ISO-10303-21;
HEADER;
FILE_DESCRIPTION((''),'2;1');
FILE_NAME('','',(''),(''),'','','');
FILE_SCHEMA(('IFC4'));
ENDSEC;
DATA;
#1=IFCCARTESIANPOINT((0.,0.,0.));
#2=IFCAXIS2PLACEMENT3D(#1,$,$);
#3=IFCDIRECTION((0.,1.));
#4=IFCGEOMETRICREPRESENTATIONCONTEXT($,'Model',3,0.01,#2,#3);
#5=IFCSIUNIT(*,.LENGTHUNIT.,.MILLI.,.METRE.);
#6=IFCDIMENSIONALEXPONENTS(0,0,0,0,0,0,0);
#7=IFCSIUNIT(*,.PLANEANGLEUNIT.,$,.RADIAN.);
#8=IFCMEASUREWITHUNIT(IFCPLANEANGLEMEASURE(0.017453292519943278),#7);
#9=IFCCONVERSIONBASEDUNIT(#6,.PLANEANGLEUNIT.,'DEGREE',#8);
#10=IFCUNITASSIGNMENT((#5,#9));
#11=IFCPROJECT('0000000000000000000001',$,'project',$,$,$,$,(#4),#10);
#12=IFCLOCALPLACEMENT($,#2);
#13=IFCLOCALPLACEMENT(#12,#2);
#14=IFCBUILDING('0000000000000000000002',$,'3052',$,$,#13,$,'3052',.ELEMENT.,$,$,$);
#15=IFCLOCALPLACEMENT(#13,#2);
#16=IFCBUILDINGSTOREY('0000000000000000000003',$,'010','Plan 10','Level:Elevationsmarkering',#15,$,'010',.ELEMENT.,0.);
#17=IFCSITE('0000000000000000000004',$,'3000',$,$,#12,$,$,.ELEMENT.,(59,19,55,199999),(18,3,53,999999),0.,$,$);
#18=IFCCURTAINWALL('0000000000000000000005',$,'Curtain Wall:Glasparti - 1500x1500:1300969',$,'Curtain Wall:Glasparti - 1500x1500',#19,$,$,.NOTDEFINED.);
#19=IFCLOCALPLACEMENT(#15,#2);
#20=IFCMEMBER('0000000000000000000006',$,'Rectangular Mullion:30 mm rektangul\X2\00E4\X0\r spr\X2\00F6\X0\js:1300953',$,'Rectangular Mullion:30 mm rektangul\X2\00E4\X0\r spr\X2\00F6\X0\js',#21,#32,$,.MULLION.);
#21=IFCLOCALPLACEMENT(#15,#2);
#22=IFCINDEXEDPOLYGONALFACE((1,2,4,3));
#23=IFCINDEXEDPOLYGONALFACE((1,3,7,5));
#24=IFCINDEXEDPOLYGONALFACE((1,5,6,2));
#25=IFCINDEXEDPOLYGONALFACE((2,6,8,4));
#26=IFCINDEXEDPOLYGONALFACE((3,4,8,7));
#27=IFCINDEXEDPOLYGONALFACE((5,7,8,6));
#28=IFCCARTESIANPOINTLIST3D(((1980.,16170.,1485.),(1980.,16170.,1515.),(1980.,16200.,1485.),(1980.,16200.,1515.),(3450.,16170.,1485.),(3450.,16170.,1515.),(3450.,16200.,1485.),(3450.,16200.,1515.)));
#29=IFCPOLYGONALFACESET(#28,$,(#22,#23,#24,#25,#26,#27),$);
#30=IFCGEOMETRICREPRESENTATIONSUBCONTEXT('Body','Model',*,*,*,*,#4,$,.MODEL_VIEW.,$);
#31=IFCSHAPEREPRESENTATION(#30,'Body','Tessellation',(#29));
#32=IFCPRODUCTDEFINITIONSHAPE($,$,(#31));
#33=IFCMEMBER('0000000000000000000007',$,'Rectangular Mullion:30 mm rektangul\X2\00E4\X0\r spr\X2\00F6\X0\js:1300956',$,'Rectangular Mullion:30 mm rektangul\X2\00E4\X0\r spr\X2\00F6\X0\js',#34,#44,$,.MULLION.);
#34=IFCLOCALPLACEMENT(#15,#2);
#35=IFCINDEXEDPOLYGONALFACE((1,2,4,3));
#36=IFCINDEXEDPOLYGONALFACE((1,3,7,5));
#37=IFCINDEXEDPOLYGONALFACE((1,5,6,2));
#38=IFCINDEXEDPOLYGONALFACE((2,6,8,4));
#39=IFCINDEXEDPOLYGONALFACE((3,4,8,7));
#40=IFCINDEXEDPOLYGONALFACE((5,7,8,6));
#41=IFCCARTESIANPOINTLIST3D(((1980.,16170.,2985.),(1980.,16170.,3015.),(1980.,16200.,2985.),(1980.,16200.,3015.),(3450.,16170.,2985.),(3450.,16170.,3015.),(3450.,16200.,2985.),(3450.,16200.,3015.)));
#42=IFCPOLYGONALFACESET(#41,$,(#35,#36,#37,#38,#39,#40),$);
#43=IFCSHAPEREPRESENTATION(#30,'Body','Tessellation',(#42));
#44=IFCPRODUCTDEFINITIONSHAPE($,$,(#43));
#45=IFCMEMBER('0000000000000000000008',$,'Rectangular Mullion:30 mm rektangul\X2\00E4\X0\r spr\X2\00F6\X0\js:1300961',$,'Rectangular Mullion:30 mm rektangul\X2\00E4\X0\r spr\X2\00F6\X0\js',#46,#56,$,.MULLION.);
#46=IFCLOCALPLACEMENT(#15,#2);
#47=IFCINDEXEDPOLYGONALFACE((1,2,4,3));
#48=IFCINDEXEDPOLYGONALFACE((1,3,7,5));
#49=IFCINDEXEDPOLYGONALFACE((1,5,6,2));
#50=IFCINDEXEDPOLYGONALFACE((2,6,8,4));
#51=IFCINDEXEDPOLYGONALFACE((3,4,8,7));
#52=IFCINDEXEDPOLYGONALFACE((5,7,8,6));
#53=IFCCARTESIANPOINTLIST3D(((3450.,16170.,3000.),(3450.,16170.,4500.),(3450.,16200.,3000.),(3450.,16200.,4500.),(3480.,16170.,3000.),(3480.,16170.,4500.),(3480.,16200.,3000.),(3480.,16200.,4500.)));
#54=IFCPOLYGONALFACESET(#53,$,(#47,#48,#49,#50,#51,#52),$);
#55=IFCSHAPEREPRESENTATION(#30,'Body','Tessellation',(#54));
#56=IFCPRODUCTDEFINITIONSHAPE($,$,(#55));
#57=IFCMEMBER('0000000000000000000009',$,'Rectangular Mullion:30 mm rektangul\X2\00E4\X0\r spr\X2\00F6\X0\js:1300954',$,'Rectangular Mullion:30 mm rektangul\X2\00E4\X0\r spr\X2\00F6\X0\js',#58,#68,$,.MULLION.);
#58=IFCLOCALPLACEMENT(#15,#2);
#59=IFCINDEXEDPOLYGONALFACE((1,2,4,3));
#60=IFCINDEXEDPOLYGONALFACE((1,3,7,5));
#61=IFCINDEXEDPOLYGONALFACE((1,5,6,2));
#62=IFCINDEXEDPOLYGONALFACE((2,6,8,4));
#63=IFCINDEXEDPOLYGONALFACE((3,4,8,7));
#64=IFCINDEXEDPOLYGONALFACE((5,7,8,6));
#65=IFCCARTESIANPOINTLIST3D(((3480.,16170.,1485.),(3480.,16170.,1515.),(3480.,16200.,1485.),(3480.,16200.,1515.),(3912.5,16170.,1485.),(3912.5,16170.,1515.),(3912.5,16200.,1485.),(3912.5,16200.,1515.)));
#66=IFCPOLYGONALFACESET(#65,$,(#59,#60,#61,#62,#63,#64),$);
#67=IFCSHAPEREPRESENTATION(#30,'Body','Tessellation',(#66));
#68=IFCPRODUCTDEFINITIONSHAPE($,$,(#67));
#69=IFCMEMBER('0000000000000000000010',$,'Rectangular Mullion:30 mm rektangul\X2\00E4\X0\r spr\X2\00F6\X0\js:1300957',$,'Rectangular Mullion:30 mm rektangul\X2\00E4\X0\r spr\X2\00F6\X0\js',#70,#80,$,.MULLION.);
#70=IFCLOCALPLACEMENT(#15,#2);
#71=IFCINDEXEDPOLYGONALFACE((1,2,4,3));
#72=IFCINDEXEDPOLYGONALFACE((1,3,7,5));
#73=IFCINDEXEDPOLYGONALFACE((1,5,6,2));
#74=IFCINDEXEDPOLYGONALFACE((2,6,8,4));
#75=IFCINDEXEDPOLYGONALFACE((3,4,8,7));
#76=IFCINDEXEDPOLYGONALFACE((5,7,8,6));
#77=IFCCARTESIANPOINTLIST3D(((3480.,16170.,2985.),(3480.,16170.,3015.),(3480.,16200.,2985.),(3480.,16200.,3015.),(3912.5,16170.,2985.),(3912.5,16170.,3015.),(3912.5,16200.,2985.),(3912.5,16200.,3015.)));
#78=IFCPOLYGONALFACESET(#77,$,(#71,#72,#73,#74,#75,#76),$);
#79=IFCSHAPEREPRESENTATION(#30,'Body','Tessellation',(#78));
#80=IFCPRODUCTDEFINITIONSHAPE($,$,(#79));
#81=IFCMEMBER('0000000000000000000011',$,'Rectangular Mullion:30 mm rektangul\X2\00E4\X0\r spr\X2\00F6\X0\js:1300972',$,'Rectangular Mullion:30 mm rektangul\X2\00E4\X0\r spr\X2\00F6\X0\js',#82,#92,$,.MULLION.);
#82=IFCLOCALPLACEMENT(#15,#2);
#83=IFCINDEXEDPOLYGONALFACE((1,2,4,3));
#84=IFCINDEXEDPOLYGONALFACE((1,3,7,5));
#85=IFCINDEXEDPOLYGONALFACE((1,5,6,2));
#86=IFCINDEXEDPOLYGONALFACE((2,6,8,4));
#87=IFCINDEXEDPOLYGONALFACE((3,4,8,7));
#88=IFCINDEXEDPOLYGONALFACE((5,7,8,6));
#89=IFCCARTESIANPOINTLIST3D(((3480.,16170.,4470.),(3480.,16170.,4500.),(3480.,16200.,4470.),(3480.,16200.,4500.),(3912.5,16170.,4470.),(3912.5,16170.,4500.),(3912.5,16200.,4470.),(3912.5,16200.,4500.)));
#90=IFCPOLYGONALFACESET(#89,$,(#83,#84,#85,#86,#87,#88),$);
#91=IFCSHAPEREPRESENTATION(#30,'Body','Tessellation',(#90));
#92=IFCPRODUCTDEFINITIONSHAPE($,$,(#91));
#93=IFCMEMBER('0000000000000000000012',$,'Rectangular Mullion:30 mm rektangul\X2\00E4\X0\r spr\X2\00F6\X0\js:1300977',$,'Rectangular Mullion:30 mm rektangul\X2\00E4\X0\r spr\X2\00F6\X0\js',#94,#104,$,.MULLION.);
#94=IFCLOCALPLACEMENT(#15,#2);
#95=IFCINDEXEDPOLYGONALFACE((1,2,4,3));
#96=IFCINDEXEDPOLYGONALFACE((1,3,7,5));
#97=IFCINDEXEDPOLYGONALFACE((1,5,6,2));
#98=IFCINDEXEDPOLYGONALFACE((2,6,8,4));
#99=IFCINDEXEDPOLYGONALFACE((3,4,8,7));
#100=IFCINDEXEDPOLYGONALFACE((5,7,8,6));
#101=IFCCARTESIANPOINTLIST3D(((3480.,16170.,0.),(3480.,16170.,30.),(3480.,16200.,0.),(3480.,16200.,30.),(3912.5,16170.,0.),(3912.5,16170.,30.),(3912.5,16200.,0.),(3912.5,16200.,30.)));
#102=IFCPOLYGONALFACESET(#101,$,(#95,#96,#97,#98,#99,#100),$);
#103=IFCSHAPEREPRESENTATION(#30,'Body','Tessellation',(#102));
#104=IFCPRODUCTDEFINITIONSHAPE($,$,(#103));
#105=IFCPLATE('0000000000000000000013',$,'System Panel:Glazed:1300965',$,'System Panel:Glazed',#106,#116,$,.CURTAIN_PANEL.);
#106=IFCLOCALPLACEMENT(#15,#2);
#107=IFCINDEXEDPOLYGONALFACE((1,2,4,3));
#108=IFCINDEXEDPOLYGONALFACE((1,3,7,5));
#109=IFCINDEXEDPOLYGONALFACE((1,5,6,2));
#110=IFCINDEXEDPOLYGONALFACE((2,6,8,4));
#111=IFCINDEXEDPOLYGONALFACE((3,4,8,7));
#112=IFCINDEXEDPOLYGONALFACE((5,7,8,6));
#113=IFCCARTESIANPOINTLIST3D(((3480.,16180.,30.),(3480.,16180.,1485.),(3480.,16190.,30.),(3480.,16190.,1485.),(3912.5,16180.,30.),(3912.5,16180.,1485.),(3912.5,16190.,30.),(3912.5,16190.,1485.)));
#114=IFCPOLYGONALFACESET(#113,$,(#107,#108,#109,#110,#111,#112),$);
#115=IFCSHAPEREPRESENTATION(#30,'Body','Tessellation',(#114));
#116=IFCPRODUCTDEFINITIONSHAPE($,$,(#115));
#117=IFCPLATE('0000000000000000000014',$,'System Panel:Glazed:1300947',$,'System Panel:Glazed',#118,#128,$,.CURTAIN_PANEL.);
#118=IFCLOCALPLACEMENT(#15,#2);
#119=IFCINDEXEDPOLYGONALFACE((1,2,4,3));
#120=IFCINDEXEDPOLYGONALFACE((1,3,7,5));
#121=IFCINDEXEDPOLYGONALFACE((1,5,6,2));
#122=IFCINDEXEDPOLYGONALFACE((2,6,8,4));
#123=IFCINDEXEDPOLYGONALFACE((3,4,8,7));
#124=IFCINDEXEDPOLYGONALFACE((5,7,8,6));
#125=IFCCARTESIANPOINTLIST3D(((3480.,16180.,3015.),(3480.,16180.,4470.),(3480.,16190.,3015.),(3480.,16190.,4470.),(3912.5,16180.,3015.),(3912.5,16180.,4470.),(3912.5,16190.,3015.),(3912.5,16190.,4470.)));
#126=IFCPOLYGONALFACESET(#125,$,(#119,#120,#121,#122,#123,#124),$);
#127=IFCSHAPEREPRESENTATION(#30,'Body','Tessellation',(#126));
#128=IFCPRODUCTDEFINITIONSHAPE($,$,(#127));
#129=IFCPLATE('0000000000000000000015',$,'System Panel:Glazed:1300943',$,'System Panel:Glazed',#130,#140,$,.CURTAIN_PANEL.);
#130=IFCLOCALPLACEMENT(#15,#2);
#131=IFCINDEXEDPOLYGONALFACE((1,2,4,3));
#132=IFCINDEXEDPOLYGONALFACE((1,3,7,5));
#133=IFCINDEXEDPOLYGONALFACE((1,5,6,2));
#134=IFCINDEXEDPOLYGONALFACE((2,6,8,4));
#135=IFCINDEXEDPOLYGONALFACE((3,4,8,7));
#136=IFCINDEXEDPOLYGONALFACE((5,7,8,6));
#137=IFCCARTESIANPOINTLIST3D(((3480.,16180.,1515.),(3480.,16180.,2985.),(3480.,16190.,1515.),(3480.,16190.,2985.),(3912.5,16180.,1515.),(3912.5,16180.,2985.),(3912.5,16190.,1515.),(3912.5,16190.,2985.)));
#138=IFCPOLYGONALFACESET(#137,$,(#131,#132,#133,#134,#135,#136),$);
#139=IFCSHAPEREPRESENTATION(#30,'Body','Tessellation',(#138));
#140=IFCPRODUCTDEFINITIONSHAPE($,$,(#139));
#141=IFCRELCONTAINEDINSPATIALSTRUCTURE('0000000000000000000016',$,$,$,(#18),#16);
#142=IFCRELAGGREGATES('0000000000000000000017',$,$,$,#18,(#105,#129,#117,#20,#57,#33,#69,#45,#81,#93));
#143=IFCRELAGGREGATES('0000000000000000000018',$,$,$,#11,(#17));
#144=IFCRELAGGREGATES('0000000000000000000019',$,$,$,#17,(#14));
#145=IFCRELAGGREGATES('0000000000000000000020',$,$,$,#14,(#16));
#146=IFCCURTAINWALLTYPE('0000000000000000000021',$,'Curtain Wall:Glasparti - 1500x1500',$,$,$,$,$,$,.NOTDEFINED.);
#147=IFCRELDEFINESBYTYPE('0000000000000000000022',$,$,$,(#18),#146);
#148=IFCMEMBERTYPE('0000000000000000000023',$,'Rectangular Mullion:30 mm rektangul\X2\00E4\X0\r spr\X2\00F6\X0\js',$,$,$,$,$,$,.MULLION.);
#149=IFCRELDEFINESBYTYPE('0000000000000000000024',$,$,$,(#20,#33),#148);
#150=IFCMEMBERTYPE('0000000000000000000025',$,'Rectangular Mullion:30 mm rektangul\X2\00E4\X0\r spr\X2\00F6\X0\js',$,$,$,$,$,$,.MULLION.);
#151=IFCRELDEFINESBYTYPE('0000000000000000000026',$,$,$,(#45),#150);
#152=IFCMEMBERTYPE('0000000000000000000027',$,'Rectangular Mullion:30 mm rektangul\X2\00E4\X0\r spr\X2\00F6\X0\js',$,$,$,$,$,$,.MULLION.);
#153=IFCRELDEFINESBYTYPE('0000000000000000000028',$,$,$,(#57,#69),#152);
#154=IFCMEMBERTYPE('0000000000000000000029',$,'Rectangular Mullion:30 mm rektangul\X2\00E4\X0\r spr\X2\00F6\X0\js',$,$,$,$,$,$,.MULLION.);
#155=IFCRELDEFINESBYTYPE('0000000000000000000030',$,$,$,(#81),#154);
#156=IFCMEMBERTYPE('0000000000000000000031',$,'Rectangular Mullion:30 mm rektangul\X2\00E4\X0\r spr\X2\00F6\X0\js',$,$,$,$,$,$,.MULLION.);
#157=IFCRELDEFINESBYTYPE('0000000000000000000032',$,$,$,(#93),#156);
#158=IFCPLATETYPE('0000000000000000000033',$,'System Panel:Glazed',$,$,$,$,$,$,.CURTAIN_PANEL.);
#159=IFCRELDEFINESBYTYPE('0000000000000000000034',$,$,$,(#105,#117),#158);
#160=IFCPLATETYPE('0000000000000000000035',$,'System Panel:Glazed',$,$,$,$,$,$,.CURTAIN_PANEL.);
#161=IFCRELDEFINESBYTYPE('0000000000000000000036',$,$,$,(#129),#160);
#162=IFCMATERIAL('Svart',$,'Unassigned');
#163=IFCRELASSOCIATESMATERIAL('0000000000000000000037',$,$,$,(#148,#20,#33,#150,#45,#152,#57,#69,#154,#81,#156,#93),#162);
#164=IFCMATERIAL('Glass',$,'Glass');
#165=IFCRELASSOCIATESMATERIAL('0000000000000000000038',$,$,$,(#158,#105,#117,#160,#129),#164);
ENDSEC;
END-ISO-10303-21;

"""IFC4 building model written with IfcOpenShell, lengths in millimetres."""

from ifc_helpers import new_model, entity, si_unit, converted_unit, direction, frame, origin, place, context, subcontext, project, spatial, indexed_curve, outline, extrude, source, transform, mapped, material, type_object, type_shapes, element, aggregate, save


model = new_model("IFC4")

# Units and contexts
model_context = context("Model", 3, precision=0.01, world=origin(), true_north=direction((0.0, 1.0)))
body_context = subcontext(model_context, "Body", "Model", "MODEL_VIEW")
ifc_project = project(units=[si_unit("LENGTHUNIT", "METRE", prefix="MILLI"), converted_unit("PLANEANGLEUNIT", "DEGREE", entity("IfcPlaneAngleMeasure", 0.017453292519943278), si_unit("PLANEANGLEUNIT", "RADIAN"), dimensions=[0, 0, 0, 0, 0, 0, 0])], contexts=[model_context])

# Site, building, storey
site_placement = place(None, origin())
site = spatial("IfcSite", under=ifc_project, at=site_placement, Name="3000", CompositionType="ELEMENT", RefLatitude=(59, 19, 55, 199999), RefLongitude=(18, 3, 53, 999999), RefElevation=0.0)
building_placement = place(site_placement, origin())
building = spatial("IfcBuilding", under=site, at=building_placement, Name="3052", LongName="3052", CompositionType="ELEMENT")
storey_placement = place(building_placement, origin())
storey = spatial("IfcBuildingStorey", under=building, at=storey_placement, Name="010", Description="Plan 10", ObjectType="Level:Elevationsmarkering", LongName="010", CompositionType="ELEMENT", Elevation=0.0)

# Curtain wall
curtain_wall_type = type_object("IfcCurtainWallType", Name="Curtain Wall:Glasparti - 1500x1500", PredefinedType="NOTDEFINED")
curtain_wall_1_placement = place(storey_placement, origin())
curtain_wall_1 = element("IfcCurtainWall", 1, at=curtain_wall_1_placement, inside=storey, type_object=curtain_wall_type, Name="Curtain Wall:Glasparti - 1500x1500:1300969", ObjectType="Curtain Wall:Glasparti - 1500x1500", PredefinedType="NOTDEFINED")
ifc_material_1 = material(Name="Svart", Category="Unassigned")

# Members
member_type_1 = type_object("IfcMemberType", Name="Rectangular Mullion:30 mm rektangulär spröjs", PredefinedType="MULLION", material=ifc_material_1)
shared_shape_1 = source(origin(), body_context, "Body", "SweptSolid", [
    extrude(outline(indexed_curve([(-15.0, -15.0), (15.0, -15.0), (15.0, 15.0), (-15.0, 15.0), (-15.0, -15.0)], self_intersect=False)), frame((0.0, 0.0, -1470.0), z_axis=(0.0, 0.0, 1.0), x_axis=(-1.0, 0.0, 0.0)), (0.0, 0.0, 1.0), 1470.0),
])
type_shapes(member_type_1, [shared_shape_1])
member_1_placement = place(curtain_wall_1_placement, frame((3450.0, 16185.0, 1500.0), z_axis=(1.0, 0.0, 0.0), x_axis=(0.0, 0.0, 1.0)))
member_1 = element("IfcMember", 2, at=member_1_placement, type_object=member_type_1, material=ifc_material_1, Name="Rectangular Mullion:30 mm rektangulär spröjs:1300953", ObjectType="Rectangular Mullion:30 mm rektangulär spröjs", PredefinedType="MULLION", context=body_context, shape_type="MappedRepresentation", body=[
    mapped(shared_shape_1, transform((0.0, 0.0, 0.0), scale=1.0)),
])
member_2_placement = place(curtain_wall_1_placement, frame((3450.0, 16185.0, 3000.0), z_axis=(1.0, 0.0, 0.0), x_axis=(0.0, 0.0, 1.0)))
member_2 = element("IfcMember", 3, at=member_2_placement, type_object=member_type_1, material=ifc_material_1, Name="Rectangular Mullion:30 mm rektangulär spröjs:1300956", ObjectType="Rectangular Mullion:30 mm rektangulär spröjs", PredefinedType="MULLION", context=body_context, shape_type="MappedRepresentation", body=[
    mapped(shared_shape_1, transform((0.0, 0.0, 0.0), scale=1.0)),
])
member_type_2 = type_object("IfcMemberType", Name="Rectangular Mullion:30 mm rektangulär spröjs", PredefinedType="MULLION", material=ifc_material_1)
shared_shape_2 = source(origin(), body_context, "Body", "SweptSolid", [
    extrude(outline(indexed_curve([(-15.0, -15.0), (15.0, -15.0), (15.0, 15.0), (-15.0, 15.0), (-15.0, -15.0)], self_intersect=False)), frame((0.0, 0.0, -1500.0), z_axis=(0.0, 0.0, 1.0), x_axis=(-1.0, 0.0, 0.0)), (0.0, 0.0, 1.0), 1500.0),
])
type_shapes(member_type_2, [shared_shape_2])
member_3_placement = place(curtain_wall_1_placement, frame((3465.0, 16185.0, 3000.0), z_axis=(0.0, 0.0, -1.0), x_axis=(1.0, 0.0, 0.0)))
member_3 = element("IfcMember", 4, at=member_3_placement, type_object=member_type_2, material=ifc_material_1, Name="Rectangular Mullion:30 mm rektangulär spröjs:1300961", ObjectType="Rectangular Mullion:30 mm rektangulär spröjs", PredefinedType="MULLION", context=body_context, shape_type="MappedRepresentation", body=[
    mapped(shared_shape_2, transform((0.0, 0.0, 0.0), scale=1.0)),
])
member_type_3 = type_object("IfcMemberType", Name="Rectangular Mullion:30 mm rektangulär spröjs", PredefinedType="MULLION", material=ifc_material_1)
shared_shape_3 = source(origin(), body_context, "Body", "SweptSolid", [
    extrude(outline(indexed_curve([(-15.0, -15.0), (15.0, -15.0), (15.0, 15.0), (-15.0, 15.0), (-15.0, -15.0)], self_intersect=False)), frame((0.0, 0.0, -432.5), z_axis=(0.0, 0.0, 1.0), x_axis=(-1.0, 0.0, 0.0)), (0.0, 0.0, 1.0), 432.5),
])
type_shapes(member_type_3, [shared_shape_3])
member_4_placement = place(curtain_wall_1_placement, frame((3912.5, 16185.0, 1500.0), z_axis=(1.0, 0.0, 0.0), x_axis=(0.0, 0.0, 1.0)))
member_4 = element("IfcMember", 5, at=member_4_placement, type_object=member_type_3, material=ifc_material_1, Name="Rectangular Mullion:30 mm rektangulär spröjs:1300954", ObjectType="Rectangular Mullion:30 mm rektangulär spröjs", PredefinedType="MULLION", context=body_context, shape_type="MappedRepresentation", body=[
    mapped(shared_shape_3, transform((0.0, 0.0, 0.0), scale=1.0)),
])
member_5_placement = place(curtain_wall_1_placement, frame((3912.5, 16185.0, 3000.0), z_axis=(1.0, 0.0, 0.0), x_axis=(0.0, 0.0, 1.0)))
member_5 = element("IfcMember", 6, at=member_5_placement, type_object=member_type_3, material=ifc_material_1, Name="Rectangular Mullion:30 mm rektangulär spröjs:1300957", ObjectType="Rectangular Mullion:30 mm rektangulär spröjs", PredefinedType="MULLION", context=body_context, shape_type="MappedRepresentation", body=[
    mapped(shared_shape_3, transform((0.0, 0.0, 0.0), scale=1.0)),
])
member_type_4 = type_object("IfcMemberType", Name="Rectangular Mullion:30 mm rektangulär spröjs", PredefinedType="MULLION", material=ifc_material_1)
shared_shape_4 = source(origin(), body_context, "Body", "SweptSolid", [
    extrude(outline(indexed_curve([(-15.0, -15.0), (15.0, -15.0), (15.0, 15.0), (-15.0, 15.0), (-15.0, -15.0)], self_intersect=False)), frame((-15.0, 0.0, -432.5), z_axis=(0.0, 0.0, 1.0), x_axis=(-1.0, 0.0, 0.0)), (0.0, 0.0, 1.0), 432.5),
])
type_shapes(member_type_4, [shared_shape_4])
member_6_placement = place(curtain_wall_1_placement, frame((3912.5, 16185.0, 4500.0), z_axis=(1.0, 0.0, 0.0), x_axis=(0.0, 0.0, 1.0)))
member_6 = element("IfcMember", 7, at=member_6_placement, type_object=member_type_4, material=ifc_material_1, Name="Rectangular Mullion:30 mm rektangulär spröjs:1300972", ObjectType="Rectangular Mullion:30 mm rektangulär spröjs", PredefinedType="MULLION", context=body_context, shape_type="MappedRepresentation", body=[
    mapped(shared_shape_4, transform((0.0, 0.0, 0.0), scale=1.0)),
])
member_type_5 = type_object("IfcMemberType", Name="Rectangular Mullion:30 mm rektangulär spröjs", PredefinedType="MULLION", material=ifc_material_1)
shared_shape_5 = source(origin(), body_context, "Body", "SweptSolid", [
    extrude(outline(indexed_curve([(-15.0, -15.0), (15.0, -15.0), (15.0, 15.0), (-15.0, 15.0), (-15.0, -15.0)], self_intersect=False)), frame((-15.0, 0.0, -432.5), z_axis=(0.0, 0.0, 1.0), x_axis=(-1.0, 0.0, 0.0)), (0.0, 0.0, 1.0), 432.5),
])
type_shapes(member_type_5, [shared_shape_5])
member_7_placement = place(curtain_wall_1_placement, frame((3480.0, 16185.0, 0.0), z_axis=(-1.0, 0.0, 0.0), x_axis=(0.0, 0.0, -1.0)))
member_7 = element("IfcMember", 8, at=member_7_placement, type_object=member_type_5, material=ifc_material_1, Name="Rectangular Mullion:30 mm rektangulär spröjs:1300977", ObjectType="Rectangular Mullion:30 mm rektangulär spröjs", PredefinedType="MULLION", context=body_context, shape_type="MappedRepresentation", body=[
    mapped(shared_shape_5, transform((0.0, 0.0, 0.0), scale=1.0)),
])

# Plates
ifc_material_2 = material(Name="Glass", Category="Glass")
plate_type_1 = type_object("IfcPlateType", Name="System Panel:Glazed", PredefinedType="CURTAIN_PANEL", material=ifc_material_2)
shared_shape_6 = source(origin(), body_context, "Body", "SweptSolid", [
    extrude(outline(indexed_curve([(-5.0, -216.2), (5.0, -216.2), (5.0, 216.2), (-5.0, 216.2), (-5.0, -216.2)], self_intersect=False)), frame((0.0, 0.0, 0.0), z_axis=(0.0, 0.0, 1.0), x_axis=(0.0, 1.0, 0.0)), (0.0, 0.0, 1.0), 1455.0),
])
type_shapes(plate_type_1, [shared_shape_6])
plate_1_placement = place(curtain_wall_1_placement, frame((3696.3, 16185.0, 30.0)))
plate_1 = element("IfcPlate", 9, at=plate_1_placement, type_object=plate_type_1, material=ifc_material_2, Name="System Panel:Glazed:1300965", ObjectType="System Panel:Glazed", PredefinedType="CURTAIN_PANEL", context=body_context, shape_type="MappedRepresentation", body=[
    mapped(shared_shape_6, transform((0.0, 0.0, 0.0), scale=1.0)),
])
plate_2_placement = place(curtain_wall_1_placement, frame((3696.3, 16185.0, 3015.0)))
plate_2 = element("IfcPlate", 10, at=plate_2_placement, type_object=plate_type_1, material=ifc_material_2, Name="System Panel:Glazed:1300947", ObjectType="System Panel:Glazed", PredefinedType="CURTAIN_PANEL", context=body_context, shape_type="MappedRepresentation", body=[
    mapped(shared_shape_6, transform((0.0, 0.0, 0.0), scale=1.0)),
])
plate_type_2 = type_object("IfcPlateType", Name="System Panel:Glazed", PredefinedType="CURTAIN_PANEL", material=ifc_material_2)
shared_shape_7 = source(origin(), body_context, "Body", "SweptSolid", [
    extrude(outline(indexed_curve([(-5.0, -216.2), (5.0, -216.2), (5.0, 216.2), (-5.0, 216.2), (-5.0, -216.2)], self_intersect=False)), frame((0.0, 0.0, 0.0), z_axis=(0.0, 0.0, 1.0), x_axis=(0.0, 1.0, 0.0)), (0.0, 0.0, 1.0), 1470.0),
])
type_shapes(plate_type_2, [shared_shape_7])
plate_3_placement = place(curtain_wall_1_placement, frame((3696.3, 16185.0, 1515.0)))
plate_3 = element("IfcPlate", 11, at=plate_3_placement, type_object=plate_type_2, material=ifc_material_2, Name="System Panel:Glazed:1300943", ObjectType="System Panel:Glazed", PredefinedType="CURTAIN_PANEL", context=body_context, shape_type="MappedRepresentation", body=[
    mapped(shared_shape_7, transform((0.0, 0.0, 0.0), scale=1.0)),
])
aggregate(curtain_wall_1, [plate_1, plate_3, plate_2, member_1, member_4, member_2, member_5, member_3, member_6, member_7])

save(model, "model.ifc")
